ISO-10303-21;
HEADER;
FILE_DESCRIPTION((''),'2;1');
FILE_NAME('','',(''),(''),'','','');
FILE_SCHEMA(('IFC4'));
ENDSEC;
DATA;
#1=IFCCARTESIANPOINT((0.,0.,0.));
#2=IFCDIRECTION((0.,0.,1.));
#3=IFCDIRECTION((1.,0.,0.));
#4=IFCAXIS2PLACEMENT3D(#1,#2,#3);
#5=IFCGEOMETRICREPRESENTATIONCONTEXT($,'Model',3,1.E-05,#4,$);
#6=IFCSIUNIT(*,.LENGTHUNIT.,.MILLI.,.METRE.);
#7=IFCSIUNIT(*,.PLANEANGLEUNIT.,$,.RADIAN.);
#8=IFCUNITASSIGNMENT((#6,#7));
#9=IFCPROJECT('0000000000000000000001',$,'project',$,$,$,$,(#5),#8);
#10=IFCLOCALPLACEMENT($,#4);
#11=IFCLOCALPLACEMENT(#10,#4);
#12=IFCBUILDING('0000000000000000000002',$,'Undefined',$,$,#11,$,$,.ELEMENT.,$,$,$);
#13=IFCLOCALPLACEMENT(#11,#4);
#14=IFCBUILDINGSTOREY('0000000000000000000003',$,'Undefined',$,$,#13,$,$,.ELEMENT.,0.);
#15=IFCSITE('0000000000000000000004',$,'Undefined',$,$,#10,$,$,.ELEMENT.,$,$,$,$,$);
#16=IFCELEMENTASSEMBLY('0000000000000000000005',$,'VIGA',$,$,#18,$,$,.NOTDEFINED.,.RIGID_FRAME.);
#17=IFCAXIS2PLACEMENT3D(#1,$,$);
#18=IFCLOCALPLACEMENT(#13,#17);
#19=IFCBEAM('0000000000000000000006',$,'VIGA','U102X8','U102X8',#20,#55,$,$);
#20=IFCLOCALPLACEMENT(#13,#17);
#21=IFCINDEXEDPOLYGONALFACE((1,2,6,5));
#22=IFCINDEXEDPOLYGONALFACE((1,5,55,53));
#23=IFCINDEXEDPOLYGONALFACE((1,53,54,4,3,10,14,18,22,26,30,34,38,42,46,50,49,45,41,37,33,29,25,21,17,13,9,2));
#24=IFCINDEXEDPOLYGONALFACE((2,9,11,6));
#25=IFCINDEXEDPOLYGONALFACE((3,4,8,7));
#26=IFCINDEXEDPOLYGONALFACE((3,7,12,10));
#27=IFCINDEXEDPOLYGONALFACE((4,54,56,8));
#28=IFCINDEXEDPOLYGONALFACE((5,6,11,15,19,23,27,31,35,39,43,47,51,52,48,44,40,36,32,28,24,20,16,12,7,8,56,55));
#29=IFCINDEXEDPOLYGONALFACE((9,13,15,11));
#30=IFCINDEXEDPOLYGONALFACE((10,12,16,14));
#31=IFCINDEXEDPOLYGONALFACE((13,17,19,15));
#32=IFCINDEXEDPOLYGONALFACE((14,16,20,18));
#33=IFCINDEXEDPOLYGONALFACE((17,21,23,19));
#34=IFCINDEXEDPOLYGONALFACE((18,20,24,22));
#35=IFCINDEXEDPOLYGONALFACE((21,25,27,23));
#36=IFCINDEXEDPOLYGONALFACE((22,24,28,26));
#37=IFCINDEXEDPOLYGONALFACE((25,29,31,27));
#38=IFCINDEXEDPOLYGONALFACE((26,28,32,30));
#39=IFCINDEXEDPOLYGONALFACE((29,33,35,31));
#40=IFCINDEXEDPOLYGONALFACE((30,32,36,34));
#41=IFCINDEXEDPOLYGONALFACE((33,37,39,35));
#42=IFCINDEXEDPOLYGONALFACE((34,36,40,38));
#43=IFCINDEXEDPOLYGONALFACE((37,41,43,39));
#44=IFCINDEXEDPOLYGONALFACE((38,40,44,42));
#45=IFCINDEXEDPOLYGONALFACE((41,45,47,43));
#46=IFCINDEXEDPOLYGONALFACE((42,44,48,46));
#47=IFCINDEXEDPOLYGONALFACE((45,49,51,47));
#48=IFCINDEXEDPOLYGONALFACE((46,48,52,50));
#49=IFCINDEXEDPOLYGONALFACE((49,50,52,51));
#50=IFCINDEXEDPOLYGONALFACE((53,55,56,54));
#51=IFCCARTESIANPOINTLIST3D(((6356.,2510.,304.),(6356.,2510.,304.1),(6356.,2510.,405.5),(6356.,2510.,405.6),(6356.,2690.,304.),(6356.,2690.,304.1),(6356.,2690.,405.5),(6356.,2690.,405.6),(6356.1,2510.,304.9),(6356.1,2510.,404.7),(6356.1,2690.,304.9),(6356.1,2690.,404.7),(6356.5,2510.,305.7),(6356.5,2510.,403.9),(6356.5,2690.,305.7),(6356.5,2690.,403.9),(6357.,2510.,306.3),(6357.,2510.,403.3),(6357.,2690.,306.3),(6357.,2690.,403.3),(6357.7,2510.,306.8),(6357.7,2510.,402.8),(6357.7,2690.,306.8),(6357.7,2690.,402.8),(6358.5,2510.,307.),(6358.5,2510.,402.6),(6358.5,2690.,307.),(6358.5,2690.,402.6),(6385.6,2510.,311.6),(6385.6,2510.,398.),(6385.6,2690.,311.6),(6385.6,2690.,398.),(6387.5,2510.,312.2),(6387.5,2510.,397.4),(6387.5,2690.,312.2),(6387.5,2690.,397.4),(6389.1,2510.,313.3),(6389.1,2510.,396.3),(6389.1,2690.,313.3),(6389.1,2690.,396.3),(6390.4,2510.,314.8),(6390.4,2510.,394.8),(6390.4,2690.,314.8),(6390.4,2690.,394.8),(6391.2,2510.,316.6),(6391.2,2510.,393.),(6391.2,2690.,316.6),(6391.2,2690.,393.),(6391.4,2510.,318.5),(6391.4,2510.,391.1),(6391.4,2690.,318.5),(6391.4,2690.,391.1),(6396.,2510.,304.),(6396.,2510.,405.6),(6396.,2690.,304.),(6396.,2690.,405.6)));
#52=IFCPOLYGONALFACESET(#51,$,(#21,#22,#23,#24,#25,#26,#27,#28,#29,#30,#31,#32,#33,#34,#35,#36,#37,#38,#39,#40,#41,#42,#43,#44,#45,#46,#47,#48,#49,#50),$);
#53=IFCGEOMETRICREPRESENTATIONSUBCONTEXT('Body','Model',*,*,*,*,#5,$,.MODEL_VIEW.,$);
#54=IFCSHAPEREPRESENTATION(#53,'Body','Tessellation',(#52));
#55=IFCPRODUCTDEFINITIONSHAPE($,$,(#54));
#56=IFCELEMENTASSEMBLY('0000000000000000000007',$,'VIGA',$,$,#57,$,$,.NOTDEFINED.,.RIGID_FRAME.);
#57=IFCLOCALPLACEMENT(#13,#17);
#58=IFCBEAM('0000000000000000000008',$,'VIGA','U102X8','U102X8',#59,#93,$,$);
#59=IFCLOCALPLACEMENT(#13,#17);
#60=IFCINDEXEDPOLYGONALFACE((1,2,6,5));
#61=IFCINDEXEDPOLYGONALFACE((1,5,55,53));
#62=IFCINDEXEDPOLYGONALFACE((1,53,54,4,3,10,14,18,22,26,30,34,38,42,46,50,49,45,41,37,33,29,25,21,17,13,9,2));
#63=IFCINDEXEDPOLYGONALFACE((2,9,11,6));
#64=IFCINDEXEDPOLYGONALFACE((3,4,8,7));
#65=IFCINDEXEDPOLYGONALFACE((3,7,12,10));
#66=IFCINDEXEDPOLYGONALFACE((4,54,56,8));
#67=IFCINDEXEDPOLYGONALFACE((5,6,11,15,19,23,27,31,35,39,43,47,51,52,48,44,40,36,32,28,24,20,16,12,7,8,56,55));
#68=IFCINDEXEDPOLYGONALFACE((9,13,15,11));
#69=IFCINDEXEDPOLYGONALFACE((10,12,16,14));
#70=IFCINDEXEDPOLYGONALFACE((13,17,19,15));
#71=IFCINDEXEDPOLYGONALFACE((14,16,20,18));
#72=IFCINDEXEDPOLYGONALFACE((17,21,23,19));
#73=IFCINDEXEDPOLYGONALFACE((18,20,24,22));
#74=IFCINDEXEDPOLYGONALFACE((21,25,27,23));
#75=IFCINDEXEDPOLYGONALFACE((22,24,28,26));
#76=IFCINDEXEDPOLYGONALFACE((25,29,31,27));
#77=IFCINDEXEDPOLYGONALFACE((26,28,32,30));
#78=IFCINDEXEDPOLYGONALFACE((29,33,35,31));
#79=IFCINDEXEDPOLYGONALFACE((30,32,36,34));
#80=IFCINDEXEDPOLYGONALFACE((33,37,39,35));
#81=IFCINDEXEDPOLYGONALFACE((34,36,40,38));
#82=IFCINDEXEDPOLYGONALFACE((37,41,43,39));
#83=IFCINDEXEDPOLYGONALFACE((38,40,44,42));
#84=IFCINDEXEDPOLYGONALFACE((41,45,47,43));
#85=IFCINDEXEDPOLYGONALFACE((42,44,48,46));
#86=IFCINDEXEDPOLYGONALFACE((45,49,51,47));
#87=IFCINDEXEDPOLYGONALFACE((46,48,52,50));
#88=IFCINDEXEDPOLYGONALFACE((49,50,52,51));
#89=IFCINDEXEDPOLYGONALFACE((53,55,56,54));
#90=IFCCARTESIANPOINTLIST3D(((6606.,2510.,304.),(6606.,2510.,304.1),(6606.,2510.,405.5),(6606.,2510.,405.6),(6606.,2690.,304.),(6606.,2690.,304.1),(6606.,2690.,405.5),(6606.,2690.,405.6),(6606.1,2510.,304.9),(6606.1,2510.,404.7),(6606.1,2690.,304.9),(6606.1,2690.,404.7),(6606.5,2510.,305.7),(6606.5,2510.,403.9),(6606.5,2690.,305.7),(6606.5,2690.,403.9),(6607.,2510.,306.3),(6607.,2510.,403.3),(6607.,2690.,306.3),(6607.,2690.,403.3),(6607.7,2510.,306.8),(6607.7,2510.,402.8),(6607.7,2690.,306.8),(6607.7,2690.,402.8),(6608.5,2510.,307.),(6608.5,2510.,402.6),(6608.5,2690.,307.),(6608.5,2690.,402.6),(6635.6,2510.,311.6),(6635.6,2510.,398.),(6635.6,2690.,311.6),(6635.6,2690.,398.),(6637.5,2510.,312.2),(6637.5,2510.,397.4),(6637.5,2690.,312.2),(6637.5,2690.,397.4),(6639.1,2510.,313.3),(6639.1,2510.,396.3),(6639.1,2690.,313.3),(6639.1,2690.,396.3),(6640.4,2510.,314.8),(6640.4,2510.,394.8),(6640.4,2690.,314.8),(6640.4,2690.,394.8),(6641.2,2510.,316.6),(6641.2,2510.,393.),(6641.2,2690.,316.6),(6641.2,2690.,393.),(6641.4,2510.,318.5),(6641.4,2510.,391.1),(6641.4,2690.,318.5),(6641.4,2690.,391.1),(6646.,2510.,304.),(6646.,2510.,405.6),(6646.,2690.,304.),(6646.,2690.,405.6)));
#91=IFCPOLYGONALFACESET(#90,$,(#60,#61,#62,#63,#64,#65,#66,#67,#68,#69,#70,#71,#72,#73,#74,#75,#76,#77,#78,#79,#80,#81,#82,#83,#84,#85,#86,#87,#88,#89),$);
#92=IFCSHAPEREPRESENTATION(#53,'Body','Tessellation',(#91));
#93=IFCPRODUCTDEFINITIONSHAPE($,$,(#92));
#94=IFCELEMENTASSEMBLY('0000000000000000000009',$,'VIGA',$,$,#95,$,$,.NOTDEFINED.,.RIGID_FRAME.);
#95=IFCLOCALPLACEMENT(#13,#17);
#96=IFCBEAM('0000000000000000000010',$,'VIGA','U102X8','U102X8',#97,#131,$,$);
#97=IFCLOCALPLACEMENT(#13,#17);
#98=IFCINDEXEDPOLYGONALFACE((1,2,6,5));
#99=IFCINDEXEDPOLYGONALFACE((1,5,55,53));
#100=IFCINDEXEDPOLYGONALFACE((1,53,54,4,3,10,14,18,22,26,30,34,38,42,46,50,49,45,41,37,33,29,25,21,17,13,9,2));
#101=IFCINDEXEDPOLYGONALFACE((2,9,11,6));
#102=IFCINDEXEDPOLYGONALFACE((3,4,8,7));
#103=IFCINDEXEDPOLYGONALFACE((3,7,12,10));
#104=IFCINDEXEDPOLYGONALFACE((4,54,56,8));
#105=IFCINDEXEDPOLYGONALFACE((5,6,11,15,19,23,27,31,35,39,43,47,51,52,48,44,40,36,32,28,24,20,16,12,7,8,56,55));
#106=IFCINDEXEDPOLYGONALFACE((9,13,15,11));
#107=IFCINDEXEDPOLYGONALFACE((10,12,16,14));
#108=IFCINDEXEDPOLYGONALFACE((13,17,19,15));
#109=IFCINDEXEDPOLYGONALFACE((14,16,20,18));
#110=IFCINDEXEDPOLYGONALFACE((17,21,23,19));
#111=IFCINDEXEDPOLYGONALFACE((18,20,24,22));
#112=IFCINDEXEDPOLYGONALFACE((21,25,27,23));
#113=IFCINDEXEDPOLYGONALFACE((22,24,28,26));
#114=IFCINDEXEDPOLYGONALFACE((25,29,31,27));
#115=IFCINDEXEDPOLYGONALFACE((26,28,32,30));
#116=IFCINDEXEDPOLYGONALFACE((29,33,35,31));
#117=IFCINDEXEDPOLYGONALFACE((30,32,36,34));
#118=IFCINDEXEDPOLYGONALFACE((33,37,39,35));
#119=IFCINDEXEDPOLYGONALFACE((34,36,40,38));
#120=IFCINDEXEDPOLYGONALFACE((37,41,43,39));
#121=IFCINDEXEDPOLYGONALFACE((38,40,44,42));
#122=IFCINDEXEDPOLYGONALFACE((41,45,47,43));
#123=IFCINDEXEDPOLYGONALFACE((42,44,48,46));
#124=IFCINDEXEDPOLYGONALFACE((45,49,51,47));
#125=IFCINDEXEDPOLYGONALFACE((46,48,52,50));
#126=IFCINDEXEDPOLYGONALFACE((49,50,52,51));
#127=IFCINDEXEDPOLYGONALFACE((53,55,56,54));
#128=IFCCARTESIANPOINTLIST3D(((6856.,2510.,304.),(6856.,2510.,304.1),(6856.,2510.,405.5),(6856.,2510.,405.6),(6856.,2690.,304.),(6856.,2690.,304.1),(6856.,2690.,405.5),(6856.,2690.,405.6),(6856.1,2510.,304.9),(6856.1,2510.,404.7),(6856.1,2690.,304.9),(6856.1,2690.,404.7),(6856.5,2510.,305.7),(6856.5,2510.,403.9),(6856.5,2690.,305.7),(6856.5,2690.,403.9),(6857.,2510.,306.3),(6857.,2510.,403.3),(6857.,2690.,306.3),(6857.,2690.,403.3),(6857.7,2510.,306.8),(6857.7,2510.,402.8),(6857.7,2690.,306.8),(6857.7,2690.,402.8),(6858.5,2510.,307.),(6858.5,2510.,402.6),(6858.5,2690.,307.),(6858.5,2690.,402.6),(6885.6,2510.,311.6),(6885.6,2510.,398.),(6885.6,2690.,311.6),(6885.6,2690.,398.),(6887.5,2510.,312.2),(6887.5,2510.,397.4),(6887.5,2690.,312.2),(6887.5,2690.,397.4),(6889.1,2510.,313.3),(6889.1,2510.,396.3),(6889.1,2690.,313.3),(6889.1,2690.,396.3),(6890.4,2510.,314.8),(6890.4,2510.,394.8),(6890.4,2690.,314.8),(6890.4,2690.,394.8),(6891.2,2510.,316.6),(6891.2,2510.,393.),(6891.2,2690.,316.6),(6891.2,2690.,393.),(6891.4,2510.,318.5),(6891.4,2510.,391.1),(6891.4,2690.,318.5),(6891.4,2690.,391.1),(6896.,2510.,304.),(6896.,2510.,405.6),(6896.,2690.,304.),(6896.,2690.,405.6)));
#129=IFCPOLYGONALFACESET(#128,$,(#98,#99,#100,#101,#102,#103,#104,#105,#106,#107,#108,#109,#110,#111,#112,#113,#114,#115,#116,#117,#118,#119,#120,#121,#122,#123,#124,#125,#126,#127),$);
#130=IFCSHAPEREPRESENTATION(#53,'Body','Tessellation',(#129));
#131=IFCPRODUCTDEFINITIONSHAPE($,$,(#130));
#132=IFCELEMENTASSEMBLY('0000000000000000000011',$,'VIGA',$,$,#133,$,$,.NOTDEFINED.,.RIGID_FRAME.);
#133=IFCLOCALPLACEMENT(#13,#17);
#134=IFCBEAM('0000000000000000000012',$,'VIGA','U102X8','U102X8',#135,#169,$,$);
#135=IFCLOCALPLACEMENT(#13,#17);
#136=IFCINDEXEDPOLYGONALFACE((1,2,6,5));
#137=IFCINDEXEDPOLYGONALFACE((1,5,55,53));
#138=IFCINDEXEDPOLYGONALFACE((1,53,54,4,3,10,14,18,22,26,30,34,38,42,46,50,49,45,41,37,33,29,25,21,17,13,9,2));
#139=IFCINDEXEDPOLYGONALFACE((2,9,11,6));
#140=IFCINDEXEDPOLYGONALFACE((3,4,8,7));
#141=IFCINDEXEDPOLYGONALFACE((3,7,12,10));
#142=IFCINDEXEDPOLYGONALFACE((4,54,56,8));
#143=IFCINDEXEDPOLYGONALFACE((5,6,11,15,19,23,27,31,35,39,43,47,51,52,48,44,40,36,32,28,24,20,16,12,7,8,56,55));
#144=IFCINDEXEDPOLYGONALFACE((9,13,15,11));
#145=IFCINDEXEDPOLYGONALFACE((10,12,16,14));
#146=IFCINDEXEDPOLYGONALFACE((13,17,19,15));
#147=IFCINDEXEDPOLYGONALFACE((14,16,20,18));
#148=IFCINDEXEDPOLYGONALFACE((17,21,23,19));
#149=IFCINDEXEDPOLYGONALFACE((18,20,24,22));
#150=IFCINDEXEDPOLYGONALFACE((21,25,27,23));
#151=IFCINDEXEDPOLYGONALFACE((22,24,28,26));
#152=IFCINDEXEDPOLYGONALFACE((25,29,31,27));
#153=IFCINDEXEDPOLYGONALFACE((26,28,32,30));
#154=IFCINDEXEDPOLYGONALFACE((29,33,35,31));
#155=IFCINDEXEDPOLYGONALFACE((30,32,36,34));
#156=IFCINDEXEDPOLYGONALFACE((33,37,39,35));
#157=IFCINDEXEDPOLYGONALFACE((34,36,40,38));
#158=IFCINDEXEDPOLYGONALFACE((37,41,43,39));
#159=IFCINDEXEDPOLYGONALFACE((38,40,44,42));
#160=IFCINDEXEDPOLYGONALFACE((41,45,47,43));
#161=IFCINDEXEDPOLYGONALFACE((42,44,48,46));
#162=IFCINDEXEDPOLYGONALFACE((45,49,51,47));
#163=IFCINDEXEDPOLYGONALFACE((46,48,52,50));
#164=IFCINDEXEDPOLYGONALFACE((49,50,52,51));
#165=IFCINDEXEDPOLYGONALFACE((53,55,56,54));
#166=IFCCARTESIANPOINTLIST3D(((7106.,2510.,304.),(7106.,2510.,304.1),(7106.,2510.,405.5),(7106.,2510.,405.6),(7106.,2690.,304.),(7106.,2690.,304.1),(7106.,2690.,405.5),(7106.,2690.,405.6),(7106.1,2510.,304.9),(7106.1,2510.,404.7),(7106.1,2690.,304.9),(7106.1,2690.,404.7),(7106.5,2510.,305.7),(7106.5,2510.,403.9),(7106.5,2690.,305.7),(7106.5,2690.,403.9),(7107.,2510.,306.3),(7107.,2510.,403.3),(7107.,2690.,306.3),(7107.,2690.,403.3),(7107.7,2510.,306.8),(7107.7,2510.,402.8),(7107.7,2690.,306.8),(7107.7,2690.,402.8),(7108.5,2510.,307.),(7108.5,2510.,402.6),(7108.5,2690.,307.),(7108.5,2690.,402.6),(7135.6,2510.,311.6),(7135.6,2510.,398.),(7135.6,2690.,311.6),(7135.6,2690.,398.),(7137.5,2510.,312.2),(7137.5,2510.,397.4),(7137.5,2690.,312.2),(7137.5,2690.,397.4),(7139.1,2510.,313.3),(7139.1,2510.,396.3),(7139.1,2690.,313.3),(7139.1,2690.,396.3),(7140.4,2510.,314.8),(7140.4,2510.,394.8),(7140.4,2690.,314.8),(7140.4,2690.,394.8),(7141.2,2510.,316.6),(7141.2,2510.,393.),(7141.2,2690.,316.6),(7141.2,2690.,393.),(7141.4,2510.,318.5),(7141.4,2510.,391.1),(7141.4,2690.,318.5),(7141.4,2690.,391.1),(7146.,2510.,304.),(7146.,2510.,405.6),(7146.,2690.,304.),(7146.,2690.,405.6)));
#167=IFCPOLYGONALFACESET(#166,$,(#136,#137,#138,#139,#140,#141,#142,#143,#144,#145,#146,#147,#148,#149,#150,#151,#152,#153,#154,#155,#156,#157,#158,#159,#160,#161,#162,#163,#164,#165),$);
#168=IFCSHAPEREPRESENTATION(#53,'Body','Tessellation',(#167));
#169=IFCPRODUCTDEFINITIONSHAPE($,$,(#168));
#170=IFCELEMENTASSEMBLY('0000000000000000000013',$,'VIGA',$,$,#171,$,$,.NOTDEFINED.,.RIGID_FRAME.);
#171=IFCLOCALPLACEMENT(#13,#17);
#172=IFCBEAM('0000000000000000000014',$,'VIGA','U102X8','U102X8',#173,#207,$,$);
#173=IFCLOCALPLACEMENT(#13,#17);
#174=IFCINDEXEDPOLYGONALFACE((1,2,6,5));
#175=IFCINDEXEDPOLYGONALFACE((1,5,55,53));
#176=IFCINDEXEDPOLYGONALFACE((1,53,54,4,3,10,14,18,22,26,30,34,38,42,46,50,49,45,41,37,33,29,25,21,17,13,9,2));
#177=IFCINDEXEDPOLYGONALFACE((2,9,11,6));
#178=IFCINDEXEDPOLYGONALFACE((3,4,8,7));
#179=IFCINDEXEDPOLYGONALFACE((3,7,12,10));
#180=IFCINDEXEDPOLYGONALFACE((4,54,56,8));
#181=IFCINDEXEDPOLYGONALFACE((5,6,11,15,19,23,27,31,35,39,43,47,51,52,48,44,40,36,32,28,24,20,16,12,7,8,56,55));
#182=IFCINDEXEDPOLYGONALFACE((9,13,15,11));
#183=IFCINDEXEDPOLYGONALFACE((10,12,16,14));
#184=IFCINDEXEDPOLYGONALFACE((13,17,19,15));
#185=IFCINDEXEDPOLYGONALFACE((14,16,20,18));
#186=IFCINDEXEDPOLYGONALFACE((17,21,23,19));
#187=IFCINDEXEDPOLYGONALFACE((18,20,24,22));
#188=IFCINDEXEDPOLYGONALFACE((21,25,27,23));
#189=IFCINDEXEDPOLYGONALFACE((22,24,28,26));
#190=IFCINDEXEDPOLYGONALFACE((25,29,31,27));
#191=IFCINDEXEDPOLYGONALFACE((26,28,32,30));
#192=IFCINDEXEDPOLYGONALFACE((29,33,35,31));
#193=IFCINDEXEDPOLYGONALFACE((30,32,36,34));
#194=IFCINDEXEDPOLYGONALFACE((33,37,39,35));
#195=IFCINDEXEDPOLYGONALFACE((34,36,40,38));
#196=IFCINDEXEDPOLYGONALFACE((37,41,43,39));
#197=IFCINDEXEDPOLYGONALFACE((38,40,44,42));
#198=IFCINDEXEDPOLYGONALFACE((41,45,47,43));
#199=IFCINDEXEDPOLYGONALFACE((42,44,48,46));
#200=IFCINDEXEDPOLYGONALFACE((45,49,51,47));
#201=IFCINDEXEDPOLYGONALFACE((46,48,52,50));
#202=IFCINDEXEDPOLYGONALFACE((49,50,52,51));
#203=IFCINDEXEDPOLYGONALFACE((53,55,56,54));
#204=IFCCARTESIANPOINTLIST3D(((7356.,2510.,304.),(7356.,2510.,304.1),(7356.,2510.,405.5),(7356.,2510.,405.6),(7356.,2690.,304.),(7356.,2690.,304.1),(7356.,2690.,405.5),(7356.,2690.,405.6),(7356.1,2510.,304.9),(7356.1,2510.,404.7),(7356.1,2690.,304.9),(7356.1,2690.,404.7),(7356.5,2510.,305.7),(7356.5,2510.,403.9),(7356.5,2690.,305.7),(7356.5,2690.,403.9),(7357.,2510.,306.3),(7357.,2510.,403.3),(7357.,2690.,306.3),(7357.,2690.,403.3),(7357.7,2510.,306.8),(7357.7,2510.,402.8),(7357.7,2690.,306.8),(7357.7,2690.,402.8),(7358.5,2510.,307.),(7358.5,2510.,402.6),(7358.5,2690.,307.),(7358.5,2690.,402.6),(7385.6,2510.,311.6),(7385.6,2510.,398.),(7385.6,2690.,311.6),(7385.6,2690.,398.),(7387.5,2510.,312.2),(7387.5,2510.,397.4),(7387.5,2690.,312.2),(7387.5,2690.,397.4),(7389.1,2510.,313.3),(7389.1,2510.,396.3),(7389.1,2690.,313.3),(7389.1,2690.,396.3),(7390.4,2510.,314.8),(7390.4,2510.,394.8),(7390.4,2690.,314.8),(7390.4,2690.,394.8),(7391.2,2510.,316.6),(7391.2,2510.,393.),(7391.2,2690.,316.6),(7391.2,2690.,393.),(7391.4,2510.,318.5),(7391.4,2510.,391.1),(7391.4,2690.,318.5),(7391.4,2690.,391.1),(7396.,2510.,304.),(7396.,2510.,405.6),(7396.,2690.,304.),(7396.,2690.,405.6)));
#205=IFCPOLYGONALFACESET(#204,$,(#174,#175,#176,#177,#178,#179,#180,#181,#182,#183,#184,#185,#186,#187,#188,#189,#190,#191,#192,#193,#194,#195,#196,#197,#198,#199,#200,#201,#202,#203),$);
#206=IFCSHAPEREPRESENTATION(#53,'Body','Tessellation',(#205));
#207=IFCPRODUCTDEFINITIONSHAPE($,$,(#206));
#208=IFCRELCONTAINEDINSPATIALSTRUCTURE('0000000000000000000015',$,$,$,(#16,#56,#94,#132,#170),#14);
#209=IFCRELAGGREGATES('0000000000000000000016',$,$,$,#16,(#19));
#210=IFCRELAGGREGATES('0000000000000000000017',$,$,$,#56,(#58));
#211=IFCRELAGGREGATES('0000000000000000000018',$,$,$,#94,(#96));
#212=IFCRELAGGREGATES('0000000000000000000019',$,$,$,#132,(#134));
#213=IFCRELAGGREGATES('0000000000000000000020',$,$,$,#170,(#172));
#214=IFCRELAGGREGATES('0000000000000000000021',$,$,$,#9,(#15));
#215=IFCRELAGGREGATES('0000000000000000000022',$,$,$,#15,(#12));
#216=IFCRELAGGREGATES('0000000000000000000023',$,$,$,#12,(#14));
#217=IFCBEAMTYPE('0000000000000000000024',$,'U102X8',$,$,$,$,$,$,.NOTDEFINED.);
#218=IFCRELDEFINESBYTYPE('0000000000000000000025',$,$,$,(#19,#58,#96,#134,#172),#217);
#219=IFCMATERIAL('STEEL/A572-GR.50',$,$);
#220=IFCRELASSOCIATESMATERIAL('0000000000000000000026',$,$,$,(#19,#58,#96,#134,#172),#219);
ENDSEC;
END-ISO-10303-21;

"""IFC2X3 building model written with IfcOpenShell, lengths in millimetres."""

from ifc_helpers import new_model, si_unit, frame, origin_with_axes, origin_2d_with_axis, place, context, subcontext, project, spatial, u_section, extrude, material, type_object, element, aggregate, save


model = new_model("IFC2X3")

# Units and contexts
model_context = context("Model", 3, precision=1e-05, world=origin_with_axes())
body_context = subcontext(model_context, "Body", "Model", "MODEL_VIEW")
ifc_project = project(units=[si_unit("LENGTHUNIT", "METRE", prefix="MILLI"), si_unit("PLANEANGLEUNIT", "RADIAN")], contexts=[model_context])

# Site, building, storey
site_placement = place(None, origin_with_axes())
site = spatial("IfcSite", under=ifc_project, at=site_placement, Name="Undefined", CompositionType="ELEMENT")
building_placement = place(site_placement, origin_with_axes())
building = spatial("IfcBuilding", under=site, at=building_placement, Name="Undefined", CompositionType="ELEMENT")
storey_placement = place(building_placement, origin_with_axes())
storey = spatial("IfcBuildingStorey", under=building, at=storey_placement, Name="Undefined", CompositionType="ELEMENT", Elevation=0.0)

# Element assemblies, beams
ifc_material_1 = material(Name="STEEL/A572-GR.50")
beam_type_1 = type_object("IfcBeamType", Name="U102X8", PredefinedType="NOTDEFINED")
assembly_1_placement = place(storey_placement, origin_with_axes())
assembly_1 = element("IfcElementAssembly", 1, at=assembly_1_placement, inside=storey, Name="VIGA", AssemblyPlace="NOTDEFINED", PredefinedType="RIGID_FRAME")
beam_1_placement = place(assembly_1_placement, frame((6376.0, 2690.0, 354.8), z_axis=(0.0, 0.0, 1.0), x_axis=(0.0, -1.0, 0.0)))
beam_1 = element("IfcBeam", 2, at=beam_1_placement, type_object=beam_type_1, material=ifc_material_1, Name="VIGA", Description="U102X8", ObjectType="U102X8", context=body_context, shape_type="SweptSolid", body=[
    extrude(u_section(Depth=101.6, FlangeWidth=40.0, WebThickness=4.6, FlangeThickness=6.0, FilletRadius=7.0, EdgeRadius=3.0, FlangeSlope=0.16839, at=origin_2d_with_axis()), frame((180.0, 0.0, 0.0), z_axis=(-1.0, 0.0, 0.0), x_axis=(0.0, -1.0, 0.0)), (0.0, 0.0, 1.0), 180.0),
])
aggregate(assembly_1, [beam_1])
assembly_2_placement = place(storey_placement, origin_with_axes())
assembly_2 = element("IfcElementAssembly", 3, at=assembly_2_placement, inside=storey, Name="VIGA", AssemblyPlace="NOTDEFINED", PredefinedType="RIGID_FRAME")
beam_2_placement = place(assembly_2_placement, frame((6626.0, 2690.0, 354.8), z_axis=(0.0, 0.0, 1.0), x_axis=(0.0, -1.0, 0.0)))
beam_2 = element("IfcBeam", 4, at=beam_2_placement, type_object=beam_type_1, material=ifc_material_1, Name="VIGA", Description="U102X8", ObjectType="U102X8", context=body_context, shape_type="SweptSolid", body=[
    extrude(u_section(Depth=101.6, FlangeWidth=40.0, WebThickness=4.6, FlangeThickness=6.0, FilletRadius=7.0, EdgeRadius=3.0, FlangeSlope=0.16839, at=origin_2d_with_axis()), frame((180.0, 0.0, 0.0), z_axis=(-1.0, 0.0, 0.0), x_axis=(0.0, -1.0, 0.0)), (0.0, 0.0, 1.0), 180.0),
])
aggregate(assembly_2, [beam_2])
assembly_3_placement = place(storey_placement, origin_with_axes())
assembly_3 = element("IfcElementAssembly", 5, at=assembly_3_placement, inside=storey, Name="VIGA", AssemblyPlace="NOTDEFINED", PredefinedType="RIGID_FRAME")
beam_3_placement = place(assembly_3_placement, frame((6876.0, 2690.0, 354.8), z_axis=(0.0, 0.0, 1.0), x_axis=(0.0, -1.0, 0.0)))
beam_3 = element("IfcBeam", 6, at=beam_3_placement, type_object=beam_type_1, material=ifc_material_1, Name="VIGA", Description="U102X8", ObjectType="U102X8", context=body_context, shape_type="SweptSolid", body=[
    extrude(u_section(Depth=101.6, FlangeWidth=40.0, WebThickness=4.6, FlangeThickness=6.0, FilletRadius=7.0, EdgeRadius=3.0, FlangeSlope=0.16839, at=origin_2d_with_axis()), frame((180.0, 0.0, 0.0), z_axis=(-1.0, 0.0, 0.0), x_axis=(0.0, -1.0, 0.0)), (0.0, 0.0, 1.0), 180.0),
])
aggregate(assembly_3, [beam_3])
assembly_4_placement = place(storey_placement, origin_with_axes())
assembly_4 = element("IfcElementAssembly", 7, at=assembly_4_placement, inside=storey, Name="VIGA", AssemblyPlace="NOTDEFINED", PredefinedType="RIGID_FRAME")
beam_4_placement = place(assembly_4_placement, frame((7126.0, 2690.0, 354.8), z_axis=(0.0, 0.0, 1.0), x_axis=(0.0, -1.0, 0.0)))
beam_4 = element("IfcBeam", 8, at=beam_4_placement, type_object=beam_type_1, material=ifc_material_1, Name="VIGA", Description="U102X8", ObjectType="U102X8", context=body_context, shape_type="SweptSolid", body=[
    extrude(u_section(Depth=101.6, FlangeWidth=40.0, WebThickness=4.6, FlangeThickness=6.0, FilletRadius=7.0, EdgeRadius=3.0, FlangeSlope=0.16839, at=origin_2d_with_axis()), frame((180.0, 0.0, 0.0), z_axis=(-1.0, 0.0, 0.0), x_axis=(0.0, -1.0, 0.0)), (0.0, 0.0, 1.0), 180.0),
])
aggregate(assembly_4, [beam_4])
assembly_5_placement = place(storey_placement, origin_with_axes())
assembly_5 = element("IfcElementAssembly", 9, at=assembly_5_placement, inside=storey, Name="VIGA", AssemblyPlace="NOTDEFINED", PredefinedType="RIGID_FRAME")
beam_5_placement = place(assembly_5_placement, frame((7376.0, 2690.0, 354.8), z_axis=(0.0, 0.0, 1.0), x_axis=(0.0, -1.0, 0.0)))
beam_5 = element("IfcBeam", 10, at=beam_5_placement, type_object=beam_type_1, material=ifc_material_1, Name="VIGA", Description="U102X8", ObjectType="U102X8", context=body_context, shape_type="SweptSolid", body=[
    extrude(u_section(Depth=101.6, FlangeWidth=40.0, WebThickness=4.6, FlangeThickness=6.0, FilletRadius=7.0, EdgeRadius=3.0, FlangeSlope=0.16839, at=origin_2d_with_axis()), frame((180.0, 0.0, 0.0), z_axis=(-1.0, 0.0, 0.0), x_axis=(0.0, -1.0, 0.0)), (0.0, 0.0, 1.0), 180.0),
])
aggregate(assembly_5, [beam_5])

save(model, "model.ifc")
